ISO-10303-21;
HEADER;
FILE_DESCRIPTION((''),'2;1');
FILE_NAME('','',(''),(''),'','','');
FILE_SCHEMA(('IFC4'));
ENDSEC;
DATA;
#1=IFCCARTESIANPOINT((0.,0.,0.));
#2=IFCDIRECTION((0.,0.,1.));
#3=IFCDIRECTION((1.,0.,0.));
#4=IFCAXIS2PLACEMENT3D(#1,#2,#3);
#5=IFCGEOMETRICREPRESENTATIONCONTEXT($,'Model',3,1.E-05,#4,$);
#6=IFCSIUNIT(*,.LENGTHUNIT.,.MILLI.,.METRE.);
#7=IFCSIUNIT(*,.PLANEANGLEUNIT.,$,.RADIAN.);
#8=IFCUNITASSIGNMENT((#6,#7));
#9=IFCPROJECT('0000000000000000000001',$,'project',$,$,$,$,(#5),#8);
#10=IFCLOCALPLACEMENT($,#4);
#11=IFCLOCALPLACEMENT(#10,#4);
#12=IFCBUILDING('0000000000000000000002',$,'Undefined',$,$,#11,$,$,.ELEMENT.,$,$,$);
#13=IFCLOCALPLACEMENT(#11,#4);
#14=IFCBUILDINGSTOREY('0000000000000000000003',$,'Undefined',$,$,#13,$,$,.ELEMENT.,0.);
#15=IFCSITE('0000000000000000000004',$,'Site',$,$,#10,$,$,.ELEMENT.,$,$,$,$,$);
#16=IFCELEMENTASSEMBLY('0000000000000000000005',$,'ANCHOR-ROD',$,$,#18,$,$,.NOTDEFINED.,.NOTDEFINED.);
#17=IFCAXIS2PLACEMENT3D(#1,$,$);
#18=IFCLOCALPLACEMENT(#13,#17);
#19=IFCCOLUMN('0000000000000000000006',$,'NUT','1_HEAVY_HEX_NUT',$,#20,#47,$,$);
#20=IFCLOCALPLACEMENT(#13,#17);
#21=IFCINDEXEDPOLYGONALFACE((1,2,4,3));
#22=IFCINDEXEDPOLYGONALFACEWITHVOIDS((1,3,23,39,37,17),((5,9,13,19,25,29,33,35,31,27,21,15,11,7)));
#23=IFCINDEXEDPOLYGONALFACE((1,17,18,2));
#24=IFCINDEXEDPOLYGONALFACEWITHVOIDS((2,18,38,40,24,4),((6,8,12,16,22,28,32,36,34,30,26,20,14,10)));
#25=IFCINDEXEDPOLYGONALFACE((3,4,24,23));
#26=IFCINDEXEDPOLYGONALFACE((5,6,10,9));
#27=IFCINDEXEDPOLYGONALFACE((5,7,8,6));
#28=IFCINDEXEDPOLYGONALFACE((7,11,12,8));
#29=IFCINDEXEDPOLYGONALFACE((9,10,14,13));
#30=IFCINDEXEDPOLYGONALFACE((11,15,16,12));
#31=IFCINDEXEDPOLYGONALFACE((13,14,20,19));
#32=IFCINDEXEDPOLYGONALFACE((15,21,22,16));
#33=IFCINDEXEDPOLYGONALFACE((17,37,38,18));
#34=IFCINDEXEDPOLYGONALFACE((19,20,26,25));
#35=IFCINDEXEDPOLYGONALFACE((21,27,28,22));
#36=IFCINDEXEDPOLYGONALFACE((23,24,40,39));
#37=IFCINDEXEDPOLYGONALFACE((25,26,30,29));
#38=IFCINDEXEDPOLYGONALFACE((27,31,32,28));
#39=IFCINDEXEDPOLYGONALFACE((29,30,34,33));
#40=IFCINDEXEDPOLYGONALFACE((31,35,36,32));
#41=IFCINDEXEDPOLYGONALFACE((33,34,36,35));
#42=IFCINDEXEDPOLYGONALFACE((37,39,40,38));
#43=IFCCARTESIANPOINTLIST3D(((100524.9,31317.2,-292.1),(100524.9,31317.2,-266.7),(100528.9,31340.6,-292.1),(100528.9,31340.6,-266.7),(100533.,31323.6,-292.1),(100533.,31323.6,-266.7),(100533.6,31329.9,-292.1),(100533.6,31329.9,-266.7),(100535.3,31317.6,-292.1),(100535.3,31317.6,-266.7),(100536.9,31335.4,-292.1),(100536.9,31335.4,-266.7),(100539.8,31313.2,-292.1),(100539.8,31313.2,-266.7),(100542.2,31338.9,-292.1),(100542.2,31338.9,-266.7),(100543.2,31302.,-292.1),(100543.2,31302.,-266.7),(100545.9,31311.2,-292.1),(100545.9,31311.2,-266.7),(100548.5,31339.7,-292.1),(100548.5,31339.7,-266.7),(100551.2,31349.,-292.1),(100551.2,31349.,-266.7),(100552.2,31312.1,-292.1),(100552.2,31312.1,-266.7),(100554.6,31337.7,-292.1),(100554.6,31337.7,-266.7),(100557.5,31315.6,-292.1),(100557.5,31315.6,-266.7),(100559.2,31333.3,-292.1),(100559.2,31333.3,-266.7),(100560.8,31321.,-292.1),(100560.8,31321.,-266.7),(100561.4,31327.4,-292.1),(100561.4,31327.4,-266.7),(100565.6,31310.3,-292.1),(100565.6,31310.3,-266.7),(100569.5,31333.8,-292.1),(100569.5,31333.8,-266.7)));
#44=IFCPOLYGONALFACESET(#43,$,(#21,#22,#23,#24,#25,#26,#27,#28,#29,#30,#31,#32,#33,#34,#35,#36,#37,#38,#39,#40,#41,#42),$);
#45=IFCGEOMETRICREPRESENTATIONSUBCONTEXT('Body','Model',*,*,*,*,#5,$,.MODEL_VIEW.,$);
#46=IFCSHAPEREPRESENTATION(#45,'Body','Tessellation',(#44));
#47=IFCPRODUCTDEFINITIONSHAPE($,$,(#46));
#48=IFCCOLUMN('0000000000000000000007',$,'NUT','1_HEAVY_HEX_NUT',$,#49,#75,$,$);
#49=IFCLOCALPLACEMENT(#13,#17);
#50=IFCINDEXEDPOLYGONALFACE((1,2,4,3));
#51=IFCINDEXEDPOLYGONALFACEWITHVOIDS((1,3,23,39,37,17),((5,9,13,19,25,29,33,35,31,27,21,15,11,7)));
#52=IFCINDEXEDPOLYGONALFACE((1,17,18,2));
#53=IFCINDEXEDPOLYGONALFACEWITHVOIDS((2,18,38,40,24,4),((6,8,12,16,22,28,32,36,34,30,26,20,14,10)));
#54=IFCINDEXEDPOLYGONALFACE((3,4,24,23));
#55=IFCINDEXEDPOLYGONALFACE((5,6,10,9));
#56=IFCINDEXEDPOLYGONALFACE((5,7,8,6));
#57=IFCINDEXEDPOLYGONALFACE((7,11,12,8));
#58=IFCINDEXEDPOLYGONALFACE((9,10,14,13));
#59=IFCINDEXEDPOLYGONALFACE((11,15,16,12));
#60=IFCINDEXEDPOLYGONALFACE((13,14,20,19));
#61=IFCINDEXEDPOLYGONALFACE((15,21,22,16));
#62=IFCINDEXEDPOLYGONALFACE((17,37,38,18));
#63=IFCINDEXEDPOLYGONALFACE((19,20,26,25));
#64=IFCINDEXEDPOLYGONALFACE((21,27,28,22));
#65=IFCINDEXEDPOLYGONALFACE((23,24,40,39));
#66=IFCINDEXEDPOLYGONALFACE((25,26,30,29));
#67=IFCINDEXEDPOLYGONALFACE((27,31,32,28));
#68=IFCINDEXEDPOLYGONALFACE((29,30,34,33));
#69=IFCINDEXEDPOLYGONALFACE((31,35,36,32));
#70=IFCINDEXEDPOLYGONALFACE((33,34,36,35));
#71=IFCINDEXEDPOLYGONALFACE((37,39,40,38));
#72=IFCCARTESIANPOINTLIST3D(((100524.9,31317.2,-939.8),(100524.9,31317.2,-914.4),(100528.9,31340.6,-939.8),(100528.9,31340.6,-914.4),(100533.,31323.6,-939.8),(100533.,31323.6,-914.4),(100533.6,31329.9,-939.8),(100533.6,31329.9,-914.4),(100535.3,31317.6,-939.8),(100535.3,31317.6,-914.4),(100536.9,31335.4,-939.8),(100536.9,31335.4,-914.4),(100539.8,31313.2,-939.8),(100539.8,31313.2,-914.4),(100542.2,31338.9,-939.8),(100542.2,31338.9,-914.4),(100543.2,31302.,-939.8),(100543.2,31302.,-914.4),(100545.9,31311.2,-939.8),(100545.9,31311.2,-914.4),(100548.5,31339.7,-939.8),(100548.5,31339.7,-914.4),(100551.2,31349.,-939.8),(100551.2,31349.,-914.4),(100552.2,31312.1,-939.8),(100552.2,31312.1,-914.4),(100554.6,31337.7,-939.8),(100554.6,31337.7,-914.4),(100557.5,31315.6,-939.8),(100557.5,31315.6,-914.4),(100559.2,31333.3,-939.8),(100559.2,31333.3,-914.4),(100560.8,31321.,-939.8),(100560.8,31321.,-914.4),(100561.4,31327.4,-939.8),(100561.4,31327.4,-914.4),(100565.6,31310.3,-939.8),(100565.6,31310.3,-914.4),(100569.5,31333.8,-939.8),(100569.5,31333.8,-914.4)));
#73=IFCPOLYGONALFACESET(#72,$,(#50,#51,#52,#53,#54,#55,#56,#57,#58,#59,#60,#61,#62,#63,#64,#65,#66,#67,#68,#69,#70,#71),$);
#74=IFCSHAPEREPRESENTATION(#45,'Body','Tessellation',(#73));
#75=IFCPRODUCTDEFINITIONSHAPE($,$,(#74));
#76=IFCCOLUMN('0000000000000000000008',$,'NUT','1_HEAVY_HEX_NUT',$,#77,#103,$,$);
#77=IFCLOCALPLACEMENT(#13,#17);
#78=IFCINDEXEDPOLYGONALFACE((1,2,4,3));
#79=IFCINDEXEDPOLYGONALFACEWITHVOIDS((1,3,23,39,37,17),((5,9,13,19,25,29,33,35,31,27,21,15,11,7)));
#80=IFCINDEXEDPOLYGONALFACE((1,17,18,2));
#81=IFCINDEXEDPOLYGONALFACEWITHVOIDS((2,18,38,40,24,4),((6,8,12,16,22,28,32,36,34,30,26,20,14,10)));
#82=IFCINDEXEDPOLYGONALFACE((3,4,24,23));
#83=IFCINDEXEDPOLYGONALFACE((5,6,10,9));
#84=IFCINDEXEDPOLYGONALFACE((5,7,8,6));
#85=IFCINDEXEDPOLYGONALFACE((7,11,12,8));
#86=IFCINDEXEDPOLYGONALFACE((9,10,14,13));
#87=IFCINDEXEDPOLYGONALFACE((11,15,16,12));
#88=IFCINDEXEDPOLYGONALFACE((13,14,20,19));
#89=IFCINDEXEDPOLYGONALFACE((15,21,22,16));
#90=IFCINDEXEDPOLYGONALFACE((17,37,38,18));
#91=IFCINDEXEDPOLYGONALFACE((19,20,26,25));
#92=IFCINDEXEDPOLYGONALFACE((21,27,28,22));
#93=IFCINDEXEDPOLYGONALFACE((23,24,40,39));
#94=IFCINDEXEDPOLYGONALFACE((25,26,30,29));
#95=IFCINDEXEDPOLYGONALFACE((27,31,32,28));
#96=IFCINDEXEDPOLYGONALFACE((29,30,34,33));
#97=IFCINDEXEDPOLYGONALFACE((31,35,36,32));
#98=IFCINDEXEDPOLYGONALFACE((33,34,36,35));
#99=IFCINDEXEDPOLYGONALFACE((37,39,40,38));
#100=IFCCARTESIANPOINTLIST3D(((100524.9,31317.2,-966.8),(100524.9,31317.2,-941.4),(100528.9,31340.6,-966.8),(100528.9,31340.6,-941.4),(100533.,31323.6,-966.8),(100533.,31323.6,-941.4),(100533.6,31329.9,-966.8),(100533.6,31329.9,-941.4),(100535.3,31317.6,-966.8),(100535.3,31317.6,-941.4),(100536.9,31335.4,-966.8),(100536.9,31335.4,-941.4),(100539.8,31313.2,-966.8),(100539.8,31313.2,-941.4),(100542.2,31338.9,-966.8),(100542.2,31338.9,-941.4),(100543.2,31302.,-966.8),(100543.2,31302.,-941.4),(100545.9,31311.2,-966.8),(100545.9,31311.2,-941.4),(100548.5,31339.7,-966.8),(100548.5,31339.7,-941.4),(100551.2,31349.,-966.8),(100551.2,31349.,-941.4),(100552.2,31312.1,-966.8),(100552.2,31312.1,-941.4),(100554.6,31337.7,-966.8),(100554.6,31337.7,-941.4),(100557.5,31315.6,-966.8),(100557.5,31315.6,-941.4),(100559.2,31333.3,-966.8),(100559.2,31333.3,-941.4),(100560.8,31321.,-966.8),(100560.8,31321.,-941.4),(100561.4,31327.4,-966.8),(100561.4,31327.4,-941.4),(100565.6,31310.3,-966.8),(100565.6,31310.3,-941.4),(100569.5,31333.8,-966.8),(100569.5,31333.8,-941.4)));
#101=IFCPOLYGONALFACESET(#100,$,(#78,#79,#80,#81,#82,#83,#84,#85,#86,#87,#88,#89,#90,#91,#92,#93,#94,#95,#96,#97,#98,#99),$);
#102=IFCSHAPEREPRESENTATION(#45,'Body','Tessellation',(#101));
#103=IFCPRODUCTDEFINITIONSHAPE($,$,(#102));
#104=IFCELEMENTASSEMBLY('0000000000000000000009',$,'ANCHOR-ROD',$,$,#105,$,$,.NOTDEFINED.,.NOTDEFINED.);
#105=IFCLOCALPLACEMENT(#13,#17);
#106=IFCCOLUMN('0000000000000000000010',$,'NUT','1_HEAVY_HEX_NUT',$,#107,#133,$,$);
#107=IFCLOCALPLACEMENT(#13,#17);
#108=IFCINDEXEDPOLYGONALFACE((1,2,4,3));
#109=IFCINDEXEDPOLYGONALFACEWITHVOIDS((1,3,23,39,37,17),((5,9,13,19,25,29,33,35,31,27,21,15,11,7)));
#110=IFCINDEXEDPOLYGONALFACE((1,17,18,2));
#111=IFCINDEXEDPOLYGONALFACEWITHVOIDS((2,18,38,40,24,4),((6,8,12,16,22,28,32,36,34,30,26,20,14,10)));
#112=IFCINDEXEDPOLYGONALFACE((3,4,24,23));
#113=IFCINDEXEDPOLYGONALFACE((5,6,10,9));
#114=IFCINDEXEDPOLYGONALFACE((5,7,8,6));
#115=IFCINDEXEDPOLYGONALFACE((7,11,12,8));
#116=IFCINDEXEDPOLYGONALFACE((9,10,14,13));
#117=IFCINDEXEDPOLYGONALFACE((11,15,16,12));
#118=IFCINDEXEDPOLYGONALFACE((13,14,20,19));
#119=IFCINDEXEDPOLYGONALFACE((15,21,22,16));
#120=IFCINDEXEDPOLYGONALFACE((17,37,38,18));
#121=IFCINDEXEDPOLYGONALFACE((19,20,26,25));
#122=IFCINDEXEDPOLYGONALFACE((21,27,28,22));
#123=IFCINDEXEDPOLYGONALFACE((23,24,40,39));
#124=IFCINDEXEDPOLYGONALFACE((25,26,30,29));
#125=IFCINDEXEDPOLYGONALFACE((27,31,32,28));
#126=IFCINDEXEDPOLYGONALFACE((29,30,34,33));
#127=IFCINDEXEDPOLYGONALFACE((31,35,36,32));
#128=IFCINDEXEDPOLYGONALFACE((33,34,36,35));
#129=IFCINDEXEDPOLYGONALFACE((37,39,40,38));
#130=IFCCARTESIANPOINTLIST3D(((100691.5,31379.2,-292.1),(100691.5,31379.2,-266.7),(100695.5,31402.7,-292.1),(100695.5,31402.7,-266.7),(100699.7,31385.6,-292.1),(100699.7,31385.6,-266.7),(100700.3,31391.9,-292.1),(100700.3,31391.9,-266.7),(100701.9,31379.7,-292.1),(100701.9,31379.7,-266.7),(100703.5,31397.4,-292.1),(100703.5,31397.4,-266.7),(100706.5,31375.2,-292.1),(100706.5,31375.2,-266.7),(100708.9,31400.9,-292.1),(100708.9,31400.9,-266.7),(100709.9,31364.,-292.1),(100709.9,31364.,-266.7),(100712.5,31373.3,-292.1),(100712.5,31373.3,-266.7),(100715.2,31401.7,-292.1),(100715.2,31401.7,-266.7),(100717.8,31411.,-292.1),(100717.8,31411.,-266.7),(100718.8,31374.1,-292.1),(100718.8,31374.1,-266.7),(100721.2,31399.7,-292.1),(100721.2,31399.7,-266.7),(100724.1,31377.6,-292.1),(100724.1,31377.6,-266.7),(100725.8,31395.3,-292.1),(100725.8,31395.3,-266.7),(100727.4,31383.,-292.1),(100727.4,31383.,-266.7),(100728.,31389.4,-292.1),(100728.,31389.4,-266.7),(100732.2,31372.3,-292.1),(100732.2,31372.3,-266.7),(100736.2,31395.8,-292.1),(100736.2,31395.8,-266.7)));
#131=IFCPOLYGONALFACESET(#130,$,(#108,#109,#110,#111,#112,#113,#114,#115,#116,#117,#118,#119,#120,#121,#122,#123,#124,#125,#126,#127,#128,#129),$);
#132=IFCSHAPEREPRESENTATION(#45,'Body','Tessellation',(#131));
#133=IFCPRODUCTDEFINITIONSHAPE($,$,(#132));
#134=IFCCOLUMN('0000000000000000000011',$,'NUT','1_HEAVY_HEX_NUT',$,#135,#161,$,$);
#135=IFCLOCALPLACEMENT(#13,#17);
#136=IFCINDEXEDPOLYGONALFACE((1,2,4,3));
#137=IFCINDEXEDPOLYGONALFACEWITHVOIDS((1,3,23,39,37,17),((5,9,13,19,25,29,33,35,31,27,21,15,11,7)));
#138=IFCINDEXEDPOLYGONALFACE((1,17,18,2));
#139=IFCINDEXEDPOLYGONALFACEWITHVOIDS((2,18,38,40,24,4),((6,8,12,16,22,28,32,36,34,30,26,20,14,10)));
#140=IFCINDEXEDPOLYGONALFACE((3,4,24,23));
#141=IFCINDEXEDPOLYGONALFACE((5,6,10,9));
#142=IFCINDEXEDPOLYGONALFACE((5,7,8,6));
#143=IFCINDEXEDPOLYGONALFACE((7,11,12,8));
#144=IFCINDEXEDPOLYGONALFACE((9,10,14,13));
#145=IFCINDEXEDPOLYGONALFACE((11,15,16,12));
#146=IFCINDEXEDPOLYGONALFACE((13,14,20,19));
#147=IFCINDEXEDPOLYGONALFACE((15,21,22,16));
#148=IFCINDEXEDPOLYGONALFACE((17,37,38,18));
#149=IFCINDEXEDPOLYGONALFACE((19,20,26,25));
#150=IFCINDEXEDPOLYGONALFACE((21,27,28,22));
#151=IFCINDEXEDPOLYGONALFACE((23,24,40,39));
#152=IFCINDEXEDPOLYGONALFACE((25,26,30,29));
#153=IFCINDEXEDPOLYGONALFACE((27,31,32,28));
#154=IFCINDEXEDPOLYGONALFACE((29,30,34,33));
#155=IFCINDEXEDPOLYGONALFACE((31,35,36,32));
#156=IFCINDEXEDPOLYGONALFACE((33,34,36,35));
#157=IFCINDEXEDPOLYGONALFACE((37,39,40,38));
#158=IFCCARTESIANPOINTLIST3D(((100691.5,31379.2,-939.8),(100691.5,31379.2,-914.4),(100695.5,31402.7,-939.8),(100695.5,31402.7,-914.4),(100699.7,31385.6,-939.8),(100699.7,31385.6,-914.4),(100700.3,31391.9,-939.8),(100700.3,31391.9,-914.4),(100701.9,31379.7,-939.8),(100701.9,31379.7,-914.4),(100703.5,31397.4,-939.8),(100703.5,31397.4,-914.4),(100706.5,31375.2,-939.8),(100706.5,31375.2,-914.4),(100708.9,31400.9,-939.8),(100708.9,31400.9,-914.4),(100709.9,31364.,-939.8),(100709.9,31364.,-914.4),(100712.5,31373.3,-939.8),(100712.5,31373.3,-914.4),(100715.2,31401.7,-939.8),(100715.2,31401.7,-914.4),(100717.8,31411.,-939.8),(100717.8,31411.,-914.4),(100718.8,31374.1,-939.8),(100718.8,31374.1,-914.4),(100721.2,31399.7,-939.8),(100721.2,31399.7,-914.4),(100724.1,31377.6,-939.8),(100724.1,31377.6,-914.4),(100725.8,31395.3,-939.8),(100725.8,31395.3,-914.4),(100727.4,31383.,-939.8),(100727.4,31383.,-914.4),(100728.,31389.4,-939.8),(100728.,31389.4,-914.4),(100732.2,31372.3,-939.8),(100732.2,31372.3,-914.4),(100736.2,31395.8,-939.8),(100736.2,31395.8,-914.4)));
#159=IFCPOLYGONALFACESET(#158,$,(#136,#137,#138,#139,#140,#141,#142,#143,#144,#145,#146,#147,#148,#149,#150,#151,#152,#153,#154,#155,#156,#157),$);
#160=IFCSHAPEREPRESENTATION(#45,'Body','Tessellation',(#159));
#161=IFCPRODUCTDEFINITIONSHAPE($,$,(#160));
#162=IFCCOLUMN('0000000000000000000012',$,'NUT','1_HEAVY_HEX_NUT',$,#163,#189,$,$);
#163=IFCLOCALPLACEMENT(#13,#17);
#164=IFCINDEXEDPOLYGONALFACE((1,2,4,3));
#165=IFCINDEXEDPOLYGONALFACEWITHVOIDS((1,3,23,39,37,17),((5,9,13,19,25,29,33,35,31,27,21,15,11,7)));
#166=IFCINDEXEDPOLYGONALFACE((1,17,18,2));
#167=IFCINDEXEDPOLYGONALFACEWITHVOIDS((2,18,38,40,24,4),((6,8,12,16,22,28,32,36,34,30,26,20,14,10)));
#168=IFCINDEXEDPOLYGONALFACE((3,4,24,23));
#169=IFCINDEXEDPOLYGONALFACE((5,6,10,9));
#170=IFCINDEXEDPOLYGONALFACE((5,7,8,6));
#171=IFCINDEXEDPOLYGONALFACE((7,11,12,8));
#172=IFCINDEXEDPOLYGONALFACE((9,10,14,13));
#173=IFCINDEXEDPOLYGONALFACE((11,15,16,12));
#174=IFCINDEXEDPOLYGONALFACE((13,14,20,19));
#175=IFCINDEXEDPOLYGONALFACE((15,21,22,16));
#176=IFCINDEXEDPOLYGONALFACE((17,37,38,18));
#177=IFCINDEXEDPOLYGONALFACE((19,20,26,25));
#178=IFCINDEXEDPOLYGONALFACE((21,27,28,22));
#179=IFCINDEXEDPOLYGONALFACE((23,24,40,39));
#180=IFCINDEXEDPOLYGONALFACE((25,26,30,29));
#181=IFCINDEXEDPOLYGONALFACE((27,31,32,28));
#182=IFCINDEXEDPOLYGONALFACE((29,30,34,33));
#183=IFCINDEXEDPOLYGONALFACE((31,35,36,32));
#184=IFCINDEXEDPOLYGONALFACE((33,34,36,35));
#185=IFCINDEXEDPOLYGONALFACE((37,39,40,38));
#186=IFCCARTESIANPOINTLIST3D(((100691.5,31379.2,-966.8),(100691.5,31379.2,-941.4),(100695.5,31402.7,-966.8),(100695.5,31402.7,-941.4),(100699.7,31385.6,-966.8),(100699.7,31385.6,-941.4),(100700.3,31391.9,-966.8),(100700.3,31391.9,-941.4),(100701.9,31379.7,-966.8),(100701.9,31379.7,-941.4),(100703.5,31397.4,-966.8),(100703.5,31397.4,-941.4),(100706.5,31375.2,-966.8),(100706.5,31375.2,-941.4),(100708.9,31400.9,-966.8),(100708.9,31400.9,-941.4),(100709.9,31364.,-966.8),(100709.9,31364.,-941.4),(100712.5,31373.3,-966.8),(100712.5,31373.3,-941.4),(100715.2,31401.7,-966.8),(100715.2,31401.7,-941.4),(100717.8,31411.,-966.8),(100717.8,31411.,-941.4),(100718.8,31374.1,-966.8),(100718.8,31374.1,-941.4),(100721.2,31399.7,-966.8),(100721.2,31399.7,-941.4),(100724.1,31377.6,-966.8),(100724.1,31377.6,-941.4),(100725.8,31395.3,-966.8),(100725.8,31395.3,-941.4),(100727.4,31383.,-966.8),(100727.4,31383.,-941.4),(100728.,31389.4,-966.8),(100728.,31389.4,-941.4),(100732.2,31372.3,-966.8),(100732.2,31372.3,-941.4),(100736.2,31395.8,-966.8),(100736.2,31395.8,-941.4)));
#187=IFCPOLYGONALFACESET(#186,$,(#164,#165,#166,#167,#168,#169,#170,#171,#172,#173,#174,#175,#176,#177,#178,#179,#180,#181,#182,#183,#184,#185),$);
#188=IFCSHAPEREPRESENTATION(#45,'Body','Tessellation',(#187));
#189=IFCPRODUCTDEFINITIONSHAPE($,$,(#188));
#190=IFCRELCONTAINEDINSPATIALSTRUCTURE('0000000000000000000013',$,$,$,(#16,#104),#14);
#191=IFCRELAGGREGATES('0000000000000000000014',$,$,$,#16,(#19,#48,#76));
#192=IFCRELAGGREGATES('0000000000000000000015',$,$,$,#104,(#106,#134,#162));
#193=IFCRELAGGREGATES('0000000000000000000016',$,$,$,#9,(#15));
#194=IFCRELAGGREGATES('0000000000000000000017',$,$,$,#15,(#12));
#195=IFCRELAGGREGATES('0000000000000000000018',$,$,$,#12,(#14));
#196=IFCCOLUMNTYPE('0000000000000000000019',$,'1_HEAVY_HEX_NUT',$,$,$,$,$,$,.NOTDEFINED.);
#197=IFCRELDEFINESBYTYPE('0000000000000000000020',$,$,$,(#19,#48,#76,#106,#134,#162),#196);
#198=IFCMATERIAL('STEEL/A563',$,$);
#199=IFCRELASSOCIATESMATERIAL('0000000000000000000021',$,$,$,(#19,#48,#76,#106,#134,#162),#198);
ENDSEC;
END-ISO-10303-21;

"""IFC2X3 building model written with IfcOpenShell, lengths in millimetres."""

from ifc_helpers import new_model, si_unit, frame, origin_with_axes, place, context, subcontext, project, spatial, polyline, outline, extrude, material, type_object, element, aggregate, save


model = new_model("IFC2X3")

# Units and contexts
model_context = context("Model", 3, precision=1e-05, world=origin_with_axes())
body_context = subcontext(model_context, "Body", "Model", "MODEL_VIEW")
ifc_project = project(units=[si_unit("LENGTHUNIT", "METRE", prefix="MILLI"), si_unit("PLANEANGLEUNIT", "RADIAN")], contexts=[model_context])

# Site, building, storey
site_placement = place(None, origin_with_axes())
site = spatial("IfcSite", under=ifc_project, at=site_placement, Name="Site", CompositionType="ELEMENT")
building_placement = place(site_placement, origin_with_axes())
building = spatial("IfcBuilding", under=site, at=building_placement, Name="Undefined", CompositionType="ELEMENT")
storey_placement = place(building_placement, origin_with_axes())
storey = spatial("IfcBuildingStorey", under=building, at=storey_placement, Name="Undefined", CompositionType="ELEMENT", Elevation=0.0)

# Element assemblies, columns
ifc_material_1 = material(Name="STEEL/A563")
column_type_1 = type_object("IfcColumnType", Name="1_HEAVY_HEX_NUT", PredefinedType="NOTDEFINED")
assembly_1_placement = place(storey_placement, origin_with_axes())
assembly_1 = element("IfcElementAssembly", 1, at=assembly_1_placement, inside=storey, Name="ANCHOR-ROD", AssemblyPlace="NOTDEFINED", PredefinedType="NOTDEFINED")
column_1_placement = place(assembly_1_placement, frame((100547.2, 31325.5, -266.7), z_axis=(0.0, 0.0, -1.0), x_axis=(0.34879, -0.937201, 0.0)))
column_1 = element("IfcColumn", 2, at=column_1_placement, type_object=column_type_1, material=ifc_material_1, Name="NUT", Description="1_HEAVY_HEX_NUT", context=body_context, shape_type="SweptSolid", body=[
    extrude(outline(polyline([(-11.9, -20.6), (-23.8, 0.0), (-11.9, 20.6), (11.9, 20.6), (23.8, 0.0), (11.9, -20.6), (-11.9, -20.6)]), holes=[polyline([(11.2, 8.9), (6.2, 12.9), (0.0, 14.3), (-6.2, 12.9), (-11.2, 8.9), (-13.9, 3.2), (-13.9, -3.2), (-11.2, -8.9), (-6.2, -12.9), (0.0, -14.3), (6.2, -12.9), (11.2, -8.9), (13.9, -3.2), (13.9, 3.2), (11.2, 8.9)])]), frame((0.0, 0.0, 25.4), z_axis=(0.0, 0.0, -1.0), x_axis=(0.0, 1.0, 0.0)), (0.0, 0.0, 1.0), 25.4),
])
column_2_placement = place(assembly_1_placement, frame((100547.2, 31325.5, -914.4), z_axis=(0.0, 0.0, -1.0), x_axis=(0.34879, -0.937201, 0.0)))
column_2 = element("IfcColumn", 3, at=column_2_placement, type_object=column_type_1, material=ifc_material_1, Name="NUT", Description="1_HEAVY_HEX_NUT", context=body_context, shape_type="SweptSolid", body=[
    extrude(outline(polyline([(-11.9, -20.6), (-23.8, 0.0), (-11.9, 20.6), (11.9, 20.6), (23.8, 0.0), (11.9, -20.6), (-11.9, -20.6)]), holes=[polyline([(11.2, 8.9), (6.2, 12.9), (0.0, 14.3), (-6.2, 12.9), (-11.2, 8.9), (-13.9, 3.2), (-13.9, -3.2), (-11.2, -8.9), (-6.2, -12.9), (0.0, -14.3), (6.2, -12.9), (11.2, -8.9), (13.9, -3.2), (13.9, 3.2), (11.2, 8.9)])]), frame((0.0, 0.0, 25.4), z_axis=(0.0, 0.0, -1.0), x_axis=(0.0, 1.0, 0.0)), (0.0, 0.0, 1.0), 25.4),
])
column_3_placement = place(assembly_1_placement, frame((100547.2, 31325.5, -941.4), z_axis=(0.0, 0.0, -1.0), x_axis=(0.34879, -0.937201, 0.0)))
column_3 = element("IfcColumn", 4, at=column_3_placement, type_object=column_type_1, material=ifc_material_1, Name="NUT", Description="1_HEAVY_HEX_NUT", context=body_context, shape_type="SweptSolid", body=[
    extrude(outline(polyline([(-11.9, -20.6), (-23.8, 0.0), (-11.9, 20.6), (11.9, 20.6), (23.8, 0.0), (11.9, -20.6), (-11.9, -20.6)]), holes=[polyline([(11.2, 8.9), (6.2, 12.9), (0.0, 14.3), (-6.2, 12.9), (-11.2, 8.9), (-13.9, 3.2), (-13.9, -3.2), (-11.2, -8.9), (-6.2, -12.9), (0.0, -14.3), (6.2, -12.9), (11.2, -8.9), (13.9, -3.2), (13.9, 3.2), (11.2, 8.9)])]), frame((0.0, 0.0, 25.4), z_axis=(0.0, 0.0, -1.0), x_axis=(0.0, 1.0, 0.0)), (0.0, 0.0, 1.0), 25.4),
])
aggregate(assembly_1, [column_1, column_2, column_3])
assembly_2_placement = place(storey_placement, origin_with_axes())
assembly_2 = element("IfcElementAssembly", 5, at=assembly_2_placement, inside=storey, Name="ANCHOR-ROD", AssemblyPlace="NOTDEFINED", PredefinedType="NOTDEFINED")
column_4_placement = place(assembly_2_placement, frame((100713.8, 31387.5, -266.7), z_axis=(0.0, 0.0, -1.0), x_axis=(0.34879, -0.937201, 0.0)))
column_4 = element("IfcColumn", 6, at=column_4_placement, type_object=column_type_1, material=ifc_material_1, Name="NUT", Description="1_HEAVY_HEX_NUT", context=body_context, shape_type="SweptSolid", body=[
    extrude(outline(polyline([(-11.9, -20.6), (-23.8, 0.0), (-11.9, 20.6), (11.9, 20.6), (23.8, 0.0), (11.9, -20.6), (-11.9, -20.6)]), holes=[polyline([(11.2, 8.9), (6.2, 12.9), (0.0, 14.3), (-6.2, 12.9), (-11.2, 8.9), (-13.9, 3.2), (-13.9, -3.2), (-11.2, -8.9), (-6.2, -12.9), (0.0, -14.3), (6.2, -12.9), (11.2, -8.9), (13.9, -3.2), (13.9, 3.2), (11.2, 8.9)])]), frame((0.0, 0.0, 25.4), z_axis=(0.0, 0.0, -1.0), x_axis=(0.0, 1.0, 0.0)), (0.0, 0.0, 1.0), 25.4),
])
column_5_placement = place(assembly_2_placement, frame((100713.8, 31387.5, -914.4), z_axis=(0.0, 0.0, -1.0), x_axis=(0.34879, -0.937201, 0.0)))
column_5 = element("IfcColumn", 7, at=column_5_placement, type_object=column_type_1, material=ifc_material_1, Name="NUT", Description="1_HEAVY_HEX_NUT", context=body_context, shape_type="SweptSolid", body=[
    extrude(outline(polyline([(-11.9, -20.6), (-23.8, 0.0), (-11.9, 20.6), (11.9, 20.6), (23.8, 0.0), (11.9, -20.6), (-11.9, -20.6)]), holes=[polyline([(11.2, 8.9), (6.2, 12.9), (0.0, 14.3), (-6.2, 12.9), (-11.2, 8.9), (-13.9, 3.2), (-13.9, -3.2), (-11.2, -8.9), (-6.2, -12.9), (0.0, -14.3), (6.2, -12.9), (11.2, -8.9), (13.9, -3.2), (13.9, 3.2), (11.2, 8.9)])]), frame((0.0, 0.0, 25.4), z_axis=(0.0, 0.0, -1.0), x_axis=(0.0, 1.0, 0.0)), (0.0, 0.0, 1.0), 25.4),
])
column_6_placement = place(assembly_2_placement, frame((100713.8, 31387.5, -941.4), z_axis=(0.0, 0.0, -1.0), x_axis=(0.34879, -0.937201, 0.0)))
column_6 = element("IfcColumn", 8, at=column_6_placement, type_object=column_type_1, material=ifc_material_1, Name="NUT", Description="1_HEAVY_HEX_NUT", context=body_context, shape_type="SweptSolid", body=[
    extrude(outline(polyline([(-11.9, -20.6), (-23.8, 0.0), (-11.9, 20.6), (11.9, 20.6), (23.8, 0.0), (11.9, -20.6), (-11.9, -20.6)]), holes=[polyline([(11.2, 8.9), (6.2, 12.9), (0.0, 14.3), (-6.2, 12.9), (-11.2, 8.9), (-13.9, 3.2), (-13.9, -3.2), (-11.2, -8.9), (-6.2, -12.9), (0.0, -14.3), (6.2, -12.9), (11.2, -8.9), (13.9, -3.2), (13.9, 3.2), (11.2, 8.9)])]), frame((0.0, 0.0, 25.4), z_axis=(0.0, 0.0, -1.0), x_axis=(0.0, 1.0, 0.0)), (0.0, 0.0, 1.0), 25.4),
])
aggregate(assembly_2, [column_4, column_5, column_6])

save(model, "model.ifc")
